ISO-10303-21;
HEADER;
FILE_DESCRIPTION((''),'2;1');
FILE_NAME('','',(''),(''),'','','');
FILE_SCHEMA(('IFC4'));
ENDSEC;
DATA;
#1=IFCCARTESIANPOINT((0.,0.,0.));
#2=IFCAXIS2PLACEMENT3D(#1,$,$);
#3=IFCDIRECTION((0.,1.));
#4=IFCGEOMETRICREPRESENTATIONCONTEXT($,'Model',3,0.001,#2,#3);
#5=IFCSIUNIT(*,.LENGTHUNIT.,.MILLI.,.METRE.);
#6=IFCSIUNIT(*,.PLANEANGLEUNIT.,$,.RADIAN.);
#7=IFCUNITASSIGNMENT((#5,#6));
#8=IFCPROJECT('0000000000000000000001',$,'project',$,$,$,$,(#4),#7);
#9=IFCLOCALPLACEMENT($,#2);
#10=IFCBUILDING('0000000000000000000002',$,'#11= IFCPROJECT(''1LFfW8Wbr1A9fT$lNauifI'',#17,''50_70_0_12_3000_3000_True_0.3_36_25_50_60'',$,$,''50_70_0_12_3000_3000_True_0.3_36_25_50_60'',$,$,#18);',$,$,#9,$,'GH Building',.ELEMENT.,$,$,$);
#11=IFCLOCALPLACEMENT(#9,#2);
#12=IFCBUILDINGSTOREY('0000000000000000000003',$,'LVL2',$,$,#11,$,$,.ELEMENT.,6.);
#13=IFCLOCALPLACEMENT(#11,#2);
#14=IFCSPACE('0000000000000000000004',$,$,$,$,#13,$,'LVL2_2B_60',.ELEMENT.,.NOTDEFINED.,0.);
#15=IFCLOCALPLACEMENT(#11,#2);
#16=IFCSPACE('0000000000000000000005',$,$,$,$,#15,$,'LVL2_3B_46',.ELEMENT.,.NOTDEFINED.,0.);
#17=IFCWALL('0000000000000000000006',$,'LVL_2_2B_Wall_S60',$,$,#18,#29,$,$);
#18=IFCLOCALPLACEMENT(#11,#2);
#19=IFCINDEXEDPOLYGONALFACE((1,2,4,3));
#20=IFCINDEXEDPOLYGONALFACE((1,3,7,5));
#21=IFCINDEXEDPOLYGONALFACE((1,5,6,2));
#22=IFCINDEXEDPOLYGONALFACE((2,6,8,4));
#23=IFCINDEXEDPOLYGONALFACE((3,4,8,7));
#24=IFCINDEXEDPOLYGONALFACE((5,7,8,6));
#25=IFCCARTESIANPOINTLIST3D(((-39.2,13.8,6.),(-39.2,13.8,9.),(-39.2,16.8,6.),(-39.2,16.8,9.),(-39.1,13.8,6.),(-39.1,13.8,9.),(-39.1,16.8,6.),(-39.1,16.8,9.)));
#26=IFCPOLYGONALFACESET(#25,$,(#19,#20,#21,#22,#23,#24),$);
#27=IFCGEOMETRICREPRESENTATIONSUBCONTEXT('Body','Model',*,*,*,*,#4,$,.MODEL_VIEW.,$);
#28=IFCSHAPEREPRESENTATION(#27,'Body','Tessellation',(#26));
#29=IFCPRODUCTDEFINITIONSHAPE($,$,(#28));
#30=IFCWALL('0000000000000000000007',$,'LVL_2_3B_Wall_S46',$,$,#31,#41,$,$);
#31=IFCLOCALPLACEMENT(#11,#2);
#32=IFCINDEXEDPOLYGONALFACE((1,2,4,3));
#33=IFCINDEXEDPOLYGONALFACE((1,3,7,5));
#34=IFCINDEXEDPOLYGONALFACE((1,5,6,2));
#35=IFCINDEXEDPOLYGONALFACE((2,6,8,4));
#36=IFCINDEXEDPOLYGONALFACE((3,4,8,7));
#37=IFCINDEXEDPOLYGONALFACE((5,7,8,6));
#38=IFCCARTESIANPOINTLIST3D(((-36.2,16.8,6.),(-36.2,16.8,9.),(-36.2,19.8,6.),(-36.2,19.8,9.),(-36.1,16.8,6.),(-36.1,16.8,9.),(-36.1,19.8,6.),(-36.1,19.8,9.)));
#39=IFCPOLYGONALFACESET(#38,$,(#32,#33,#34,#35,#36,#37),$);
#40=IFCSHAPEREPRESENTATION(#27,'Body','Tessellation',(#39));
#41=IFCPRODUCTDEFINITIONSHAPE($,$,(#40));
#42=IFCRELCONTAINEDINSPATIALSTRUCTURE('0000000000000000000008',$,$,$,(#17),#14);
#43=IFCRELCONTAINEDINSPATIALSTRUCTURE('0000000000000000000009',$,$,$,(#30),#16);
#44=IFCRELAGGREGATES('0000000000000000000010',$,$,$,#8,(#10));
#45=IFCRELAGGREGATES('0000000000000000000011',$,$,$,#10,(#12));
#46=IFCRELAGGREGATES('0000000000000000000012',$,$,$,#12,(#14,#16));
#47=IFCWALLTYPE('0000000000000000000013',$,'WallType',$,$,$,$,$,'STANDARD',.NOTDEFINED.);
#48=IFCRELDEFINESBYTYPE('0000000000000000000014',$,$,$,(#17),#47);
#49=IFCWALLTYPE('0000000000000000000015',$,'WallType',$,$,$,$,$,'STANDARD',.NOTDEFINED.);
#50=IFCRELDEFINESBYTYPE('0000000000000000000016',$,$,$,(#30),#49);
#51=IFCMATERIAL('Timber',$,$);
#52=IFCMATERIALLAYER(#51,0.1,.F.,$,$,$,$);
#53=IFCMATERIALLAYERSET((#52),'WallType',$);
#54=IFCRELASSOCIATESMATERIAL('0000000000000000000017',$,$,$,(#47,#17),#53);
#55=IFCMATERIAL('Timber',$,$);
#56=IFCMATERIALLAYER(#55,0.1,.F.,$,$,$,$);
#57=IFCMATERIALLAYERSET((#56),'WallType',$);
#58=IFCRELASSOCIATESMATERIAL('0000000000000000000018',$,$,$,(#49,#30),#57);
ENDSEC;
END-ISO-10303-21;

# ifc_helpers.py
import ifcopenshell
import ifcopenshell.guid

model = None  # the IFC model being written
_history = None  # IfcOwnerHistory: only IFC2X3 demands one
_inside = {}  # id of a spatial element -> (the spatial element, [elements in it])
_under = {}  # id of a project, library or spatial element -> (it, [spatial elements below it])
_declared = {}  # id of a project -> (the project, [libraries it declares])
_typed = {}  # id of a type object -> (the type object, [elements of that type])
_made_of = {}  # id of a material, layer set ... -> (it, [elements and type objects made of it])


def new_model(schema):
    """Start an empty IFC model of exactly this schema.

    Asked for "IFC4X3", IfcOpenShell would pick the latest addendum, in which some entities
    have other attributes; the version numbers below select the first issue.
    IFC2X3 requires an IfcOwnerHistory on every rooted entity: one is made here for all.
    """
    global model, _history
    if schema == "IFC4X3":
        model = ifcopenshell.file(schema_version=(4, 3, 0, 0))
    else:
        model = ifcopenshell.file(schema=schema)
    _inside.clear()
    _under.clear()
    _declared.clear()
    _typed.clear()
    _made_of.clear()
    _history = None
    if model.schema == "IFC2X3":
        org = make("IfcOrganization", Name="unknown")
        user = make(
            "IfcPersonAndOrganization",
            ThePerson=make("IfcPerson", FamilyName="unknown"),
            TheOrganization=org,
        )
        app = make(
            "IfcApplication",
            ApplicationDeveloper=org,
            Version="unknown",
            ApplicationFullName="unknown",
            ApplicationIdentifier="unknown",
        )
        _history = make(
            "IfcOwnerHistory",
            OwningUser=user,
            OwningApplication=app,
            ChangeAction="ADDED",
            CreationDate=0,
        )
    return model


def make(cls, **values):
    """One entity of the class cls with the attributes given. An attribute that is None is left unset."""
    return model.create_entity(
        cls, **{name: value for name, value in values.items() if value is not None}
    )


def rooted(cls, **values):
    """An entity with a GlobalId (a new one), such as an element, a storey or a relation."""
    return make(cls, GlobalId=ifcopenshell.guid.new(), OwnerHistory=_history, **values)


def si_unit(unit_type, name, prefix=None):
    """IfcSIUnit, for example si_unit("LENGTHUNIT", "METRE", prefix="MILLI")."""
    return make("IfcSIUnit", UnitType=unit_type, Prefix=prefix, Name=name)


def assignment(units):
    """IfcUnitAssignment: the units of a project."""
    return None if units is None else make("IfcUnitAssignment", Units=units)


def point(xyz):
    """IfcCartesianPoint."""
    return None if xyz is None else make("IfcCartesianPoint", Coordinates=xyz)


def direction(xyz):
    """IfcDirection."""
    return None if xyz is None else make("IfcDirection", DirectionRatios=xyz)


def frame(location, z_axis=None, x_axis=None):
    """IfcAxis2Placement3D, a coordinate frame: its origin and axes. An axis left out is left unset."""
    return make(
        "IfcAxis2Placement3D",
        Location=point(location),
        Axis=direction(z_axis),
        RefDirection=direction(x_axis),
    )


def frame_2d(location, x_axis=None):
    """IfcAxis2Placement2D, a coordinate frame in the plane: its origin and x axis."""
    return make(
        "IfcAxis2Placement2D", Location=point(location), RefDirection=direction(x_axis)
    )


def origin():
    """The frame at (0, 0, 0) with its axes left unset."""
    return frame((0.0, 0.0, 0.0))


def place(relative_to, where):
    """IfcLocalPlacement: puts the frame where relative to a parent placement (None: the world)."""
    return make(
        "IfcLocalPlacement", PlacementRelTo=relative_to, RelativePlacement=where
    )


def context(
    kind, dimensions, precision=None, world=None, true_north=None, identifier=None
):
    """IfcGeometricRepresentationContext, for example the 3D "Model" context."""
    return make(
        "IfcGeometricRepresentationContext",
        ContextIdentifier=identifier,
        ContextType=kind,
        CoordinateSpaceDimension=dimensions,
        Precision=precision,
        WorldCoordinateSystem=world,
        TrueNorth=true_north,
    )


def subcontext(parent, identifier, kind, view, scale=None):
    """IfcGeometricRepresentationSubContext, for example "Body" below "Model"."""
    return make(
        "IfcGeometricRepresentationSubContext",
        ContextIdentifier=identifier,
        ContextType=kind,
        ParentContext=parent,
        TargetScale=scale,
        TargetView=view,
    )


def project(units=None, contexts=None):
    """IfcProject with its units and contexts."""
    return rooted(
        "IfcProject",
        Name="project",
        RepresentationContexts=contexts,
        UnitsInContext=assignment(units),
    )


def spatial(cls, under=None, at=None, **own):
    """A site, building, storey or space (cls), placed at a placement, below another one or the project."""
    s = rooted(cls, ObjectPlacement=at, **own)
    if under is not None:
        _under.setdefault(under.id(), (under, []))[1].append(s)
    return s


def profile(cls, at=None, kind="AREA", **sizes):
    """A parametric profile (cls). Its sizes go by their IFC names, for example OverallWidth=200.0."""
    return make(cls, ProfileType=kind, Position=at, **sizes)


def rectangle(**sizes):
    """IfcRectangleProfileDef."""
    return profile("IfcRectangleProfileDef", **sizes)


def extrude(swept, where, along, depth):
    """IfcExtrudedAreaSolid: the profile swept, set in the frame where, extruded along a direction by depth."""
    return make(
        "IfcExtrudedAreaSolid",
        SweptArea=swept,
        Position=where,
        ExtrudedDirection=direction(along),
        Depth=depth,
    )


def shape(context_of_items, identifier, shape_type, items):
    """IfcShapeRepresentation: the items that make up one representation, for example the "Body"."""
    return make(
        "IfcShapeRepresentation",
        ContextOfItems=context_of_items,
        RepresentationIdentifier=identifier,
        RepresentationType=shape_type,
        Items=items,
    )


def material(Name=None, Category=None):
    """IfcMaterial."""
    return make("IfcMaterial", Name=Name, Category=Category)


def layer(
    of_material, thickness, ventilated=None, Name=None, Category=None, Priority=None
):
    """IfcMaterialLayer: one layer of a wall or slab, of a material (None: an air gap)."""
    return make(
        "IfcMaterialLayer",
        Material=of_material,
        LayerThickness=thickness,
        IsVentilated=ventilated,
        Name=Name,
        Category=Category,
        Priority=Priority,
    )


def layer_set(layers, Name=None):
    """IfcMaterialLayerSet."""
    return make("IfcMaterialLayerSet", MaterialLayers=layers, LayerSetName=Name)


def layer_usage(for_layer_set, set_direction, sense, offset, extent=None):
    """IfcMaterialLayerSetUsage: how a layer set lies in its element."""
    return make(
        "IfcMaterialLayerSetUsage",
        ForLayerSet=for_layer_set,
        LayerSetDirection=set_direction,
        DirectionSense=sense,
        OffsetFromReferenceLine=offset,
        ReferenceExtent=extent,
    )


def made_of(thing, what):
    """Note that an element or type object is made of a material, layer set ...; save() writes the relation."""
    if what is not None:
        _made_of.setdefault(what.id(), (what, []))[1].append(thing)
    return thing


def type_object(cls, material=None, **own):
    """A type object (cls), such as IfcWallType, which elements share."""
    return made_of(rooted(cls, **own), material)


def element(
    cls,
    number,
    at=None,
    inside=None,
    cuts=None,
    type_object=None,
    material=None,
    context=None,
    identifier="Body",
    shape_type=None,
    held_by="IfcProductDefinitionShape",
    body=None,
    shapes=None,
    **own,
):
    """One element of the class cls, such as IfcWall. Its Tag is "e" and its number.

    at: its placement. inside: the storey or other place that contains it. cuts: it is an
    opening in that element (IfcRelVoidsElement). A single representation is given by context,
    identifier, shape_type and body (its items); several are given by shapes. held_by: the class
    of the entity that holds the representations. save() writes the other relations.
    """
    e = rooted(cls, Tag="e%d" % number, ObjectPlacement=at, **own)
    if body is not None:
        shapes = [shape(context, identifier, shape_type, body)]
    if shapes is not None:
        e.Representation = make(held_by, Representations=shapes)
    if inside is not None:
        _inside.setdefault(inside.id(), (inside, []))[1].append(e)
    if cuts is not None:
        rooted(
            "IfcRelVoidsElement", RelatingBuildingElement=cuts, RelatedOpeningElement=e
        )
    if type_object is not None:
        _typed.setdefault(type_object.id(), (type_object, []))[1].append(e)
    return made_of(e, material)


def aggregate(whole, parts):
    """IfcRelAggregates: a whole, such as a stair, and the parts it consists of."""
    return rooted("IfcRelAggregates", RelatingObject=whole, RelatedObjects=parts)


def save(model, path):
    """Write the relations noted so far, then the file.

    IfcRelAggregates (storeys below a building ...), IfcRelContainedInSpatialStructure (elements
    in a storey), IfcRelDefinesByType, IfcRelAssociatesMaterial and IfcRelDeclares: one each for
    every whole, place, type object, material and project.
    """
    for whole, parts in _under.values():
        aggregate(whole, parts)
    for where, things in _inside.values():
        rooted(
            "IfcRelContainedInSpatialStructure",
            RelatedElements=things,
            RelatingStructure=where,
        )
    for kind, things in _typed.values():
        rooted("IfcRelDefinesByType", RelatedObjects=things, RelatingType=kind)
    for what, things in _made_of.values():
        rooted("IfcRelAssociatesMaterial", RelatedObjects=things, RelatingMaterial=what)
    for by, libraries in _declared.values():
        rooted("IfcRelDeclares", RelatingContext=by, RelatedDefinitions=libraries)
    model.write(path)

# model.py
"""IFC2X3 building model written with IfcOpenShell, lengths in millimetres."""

from ifc_helpers import new_model, si_unit, direction, frame, frame_2d, origin, place, context, subcontext, project, spatial, rectangle, extrude, material, layer, layer_set, layer_usage, type_object, element, save


model = new_model("IFC2X3")

# Units and contexts
model_context = context("Model", 3, precision=0.001, world=origin(), true_north=direction((0.0, 1.0)))
body_context = subcontext(model_context, "Body", "Model", "MODEL_VIEW")
ifc_project = project(units=[si_unit("LENGTHUNIT", "METRE", prefix="MILLI"), si_unit("PLANEANGLEUNIT", "RADIAN")], contexts=[model_context])

# Building, storey
building_placement = place(None, origin())
building = spatial("IfcBuilding", under=ifc_project, at=building_placement, Name="#11= IFCPROJECT('1LFfW8Wbr1A9fT$lNauifI',#17,'50_70_0_12_3000_3000_True_0.3_36_25_50_60',$,$,'50_70_0_12_3000_3000_True_0.3_36_25_50_60',$,$,#18);", LongName="GH Building", CompositionType="ELEMENT")
storey_placement = place(building_placement, origin())
storey = spatial("IfcBuildingStorey", under=building, at=storey_placement, Name="LVL2", CompositionType="ELEMENT", Elevation=6.0)

# Shared definitions
space_1_placement = place(storey_placement, origin())
space_1 = spatial("IfcSpace", under=storey, at=space_1_placement, LongName="LVL2_2B_60", CompositionType="ELEMENT", InteriorOrExteriorSpace="NOTDEFINED", ElevationWithFlooring=0.0)

# Shared definitions
space_2_placement = place(storey_placement, origin())
space_2 = spatial("IfcSpace", under=storey, at=space_2_placement, LongName="LVL2_3B_46", CompositionType="ELEMENT", InteriorOrExteriorSpace="NOTDEFINED", ElevationWithFlooring=0.0)

# Walls
ifc_material_1 = material(Name="Timber")
ifc_layer_1 = layer(ifc_material_1, 0.1, ventilated=False)
ifc_layer_set_1 = layer_set([ifc_layer_1], Name="WallType")
ifc_layer_usage_1 = layer_usage(ifc_layer_set_1, "AXIS2", "NEGATIVE", 0.0)
wall_type_1 = type_object("IfcWallType", Name="WallType", ElementType="STANDARD", PredefinedType="NOTDEFINED", material=ifc_layer_set_1)
wall_1_placement = place(space_1_placement, frame((-39.2, 13.8, 6.0), z_axis=(0.0, 0.0, 1.0), x_axis=(0.0, 1.0, 0.0)))
element("IfcWall", 1, at=wall_1_placement, inside=space_1, type_object=wall_type_1, material=ifc_layer_usage_1, Name="LVL_2_2B_Wall_S60", context=body_context, shape_type="SweptSolid", body=[
    extrude(rectangle(XDim=3.0, YDim=0.1, at=frame_2d((1.5, -0.1))), origin(), (0.0, 0.0, 1.0), 3.0),
])
ifc_material_2 = material(Name="Timber")
ifc_layer_2 = layer(ifc_material_2, 0.1, ventilated=False)
ifc_layer_set_2 = layer_set([ifc_layer_2], Name="WallType")
ifc_layer_usage_2 = layer_usage(ifc_layer_set_2, "AXIS2", "NEGATIVE", 0.0)
wall_type_2 = type_object("IfcWallType", Name="WallType", ElementType="STANDARD", PredefinedType="NOTDEFINED", material=ifc_layer_set_2)
wall_2_placement = place(space_2_placement, frame((-36.2, 16.8, 6.0), z_axis=(0.0, 0.0, 1.0), x_axis=(0.0, 1.0, 0.0)))
element("IfcWall", 2, at=wall_2_placement, inside=space_2, type_object=wall_type_2, material=ifc_layer_usage_2, Name="LVL_2_3B_Wall_S46", context=body_context, shape_type="SweptSolid", body=[
    extrude(rectangle(XDim=3.0, YDim=0.1, at=frame_2d((1.5, -0.1))), origin(), (0.0, 0.0, 1.0), 3.0),
])

save(model, "model.ifc")
